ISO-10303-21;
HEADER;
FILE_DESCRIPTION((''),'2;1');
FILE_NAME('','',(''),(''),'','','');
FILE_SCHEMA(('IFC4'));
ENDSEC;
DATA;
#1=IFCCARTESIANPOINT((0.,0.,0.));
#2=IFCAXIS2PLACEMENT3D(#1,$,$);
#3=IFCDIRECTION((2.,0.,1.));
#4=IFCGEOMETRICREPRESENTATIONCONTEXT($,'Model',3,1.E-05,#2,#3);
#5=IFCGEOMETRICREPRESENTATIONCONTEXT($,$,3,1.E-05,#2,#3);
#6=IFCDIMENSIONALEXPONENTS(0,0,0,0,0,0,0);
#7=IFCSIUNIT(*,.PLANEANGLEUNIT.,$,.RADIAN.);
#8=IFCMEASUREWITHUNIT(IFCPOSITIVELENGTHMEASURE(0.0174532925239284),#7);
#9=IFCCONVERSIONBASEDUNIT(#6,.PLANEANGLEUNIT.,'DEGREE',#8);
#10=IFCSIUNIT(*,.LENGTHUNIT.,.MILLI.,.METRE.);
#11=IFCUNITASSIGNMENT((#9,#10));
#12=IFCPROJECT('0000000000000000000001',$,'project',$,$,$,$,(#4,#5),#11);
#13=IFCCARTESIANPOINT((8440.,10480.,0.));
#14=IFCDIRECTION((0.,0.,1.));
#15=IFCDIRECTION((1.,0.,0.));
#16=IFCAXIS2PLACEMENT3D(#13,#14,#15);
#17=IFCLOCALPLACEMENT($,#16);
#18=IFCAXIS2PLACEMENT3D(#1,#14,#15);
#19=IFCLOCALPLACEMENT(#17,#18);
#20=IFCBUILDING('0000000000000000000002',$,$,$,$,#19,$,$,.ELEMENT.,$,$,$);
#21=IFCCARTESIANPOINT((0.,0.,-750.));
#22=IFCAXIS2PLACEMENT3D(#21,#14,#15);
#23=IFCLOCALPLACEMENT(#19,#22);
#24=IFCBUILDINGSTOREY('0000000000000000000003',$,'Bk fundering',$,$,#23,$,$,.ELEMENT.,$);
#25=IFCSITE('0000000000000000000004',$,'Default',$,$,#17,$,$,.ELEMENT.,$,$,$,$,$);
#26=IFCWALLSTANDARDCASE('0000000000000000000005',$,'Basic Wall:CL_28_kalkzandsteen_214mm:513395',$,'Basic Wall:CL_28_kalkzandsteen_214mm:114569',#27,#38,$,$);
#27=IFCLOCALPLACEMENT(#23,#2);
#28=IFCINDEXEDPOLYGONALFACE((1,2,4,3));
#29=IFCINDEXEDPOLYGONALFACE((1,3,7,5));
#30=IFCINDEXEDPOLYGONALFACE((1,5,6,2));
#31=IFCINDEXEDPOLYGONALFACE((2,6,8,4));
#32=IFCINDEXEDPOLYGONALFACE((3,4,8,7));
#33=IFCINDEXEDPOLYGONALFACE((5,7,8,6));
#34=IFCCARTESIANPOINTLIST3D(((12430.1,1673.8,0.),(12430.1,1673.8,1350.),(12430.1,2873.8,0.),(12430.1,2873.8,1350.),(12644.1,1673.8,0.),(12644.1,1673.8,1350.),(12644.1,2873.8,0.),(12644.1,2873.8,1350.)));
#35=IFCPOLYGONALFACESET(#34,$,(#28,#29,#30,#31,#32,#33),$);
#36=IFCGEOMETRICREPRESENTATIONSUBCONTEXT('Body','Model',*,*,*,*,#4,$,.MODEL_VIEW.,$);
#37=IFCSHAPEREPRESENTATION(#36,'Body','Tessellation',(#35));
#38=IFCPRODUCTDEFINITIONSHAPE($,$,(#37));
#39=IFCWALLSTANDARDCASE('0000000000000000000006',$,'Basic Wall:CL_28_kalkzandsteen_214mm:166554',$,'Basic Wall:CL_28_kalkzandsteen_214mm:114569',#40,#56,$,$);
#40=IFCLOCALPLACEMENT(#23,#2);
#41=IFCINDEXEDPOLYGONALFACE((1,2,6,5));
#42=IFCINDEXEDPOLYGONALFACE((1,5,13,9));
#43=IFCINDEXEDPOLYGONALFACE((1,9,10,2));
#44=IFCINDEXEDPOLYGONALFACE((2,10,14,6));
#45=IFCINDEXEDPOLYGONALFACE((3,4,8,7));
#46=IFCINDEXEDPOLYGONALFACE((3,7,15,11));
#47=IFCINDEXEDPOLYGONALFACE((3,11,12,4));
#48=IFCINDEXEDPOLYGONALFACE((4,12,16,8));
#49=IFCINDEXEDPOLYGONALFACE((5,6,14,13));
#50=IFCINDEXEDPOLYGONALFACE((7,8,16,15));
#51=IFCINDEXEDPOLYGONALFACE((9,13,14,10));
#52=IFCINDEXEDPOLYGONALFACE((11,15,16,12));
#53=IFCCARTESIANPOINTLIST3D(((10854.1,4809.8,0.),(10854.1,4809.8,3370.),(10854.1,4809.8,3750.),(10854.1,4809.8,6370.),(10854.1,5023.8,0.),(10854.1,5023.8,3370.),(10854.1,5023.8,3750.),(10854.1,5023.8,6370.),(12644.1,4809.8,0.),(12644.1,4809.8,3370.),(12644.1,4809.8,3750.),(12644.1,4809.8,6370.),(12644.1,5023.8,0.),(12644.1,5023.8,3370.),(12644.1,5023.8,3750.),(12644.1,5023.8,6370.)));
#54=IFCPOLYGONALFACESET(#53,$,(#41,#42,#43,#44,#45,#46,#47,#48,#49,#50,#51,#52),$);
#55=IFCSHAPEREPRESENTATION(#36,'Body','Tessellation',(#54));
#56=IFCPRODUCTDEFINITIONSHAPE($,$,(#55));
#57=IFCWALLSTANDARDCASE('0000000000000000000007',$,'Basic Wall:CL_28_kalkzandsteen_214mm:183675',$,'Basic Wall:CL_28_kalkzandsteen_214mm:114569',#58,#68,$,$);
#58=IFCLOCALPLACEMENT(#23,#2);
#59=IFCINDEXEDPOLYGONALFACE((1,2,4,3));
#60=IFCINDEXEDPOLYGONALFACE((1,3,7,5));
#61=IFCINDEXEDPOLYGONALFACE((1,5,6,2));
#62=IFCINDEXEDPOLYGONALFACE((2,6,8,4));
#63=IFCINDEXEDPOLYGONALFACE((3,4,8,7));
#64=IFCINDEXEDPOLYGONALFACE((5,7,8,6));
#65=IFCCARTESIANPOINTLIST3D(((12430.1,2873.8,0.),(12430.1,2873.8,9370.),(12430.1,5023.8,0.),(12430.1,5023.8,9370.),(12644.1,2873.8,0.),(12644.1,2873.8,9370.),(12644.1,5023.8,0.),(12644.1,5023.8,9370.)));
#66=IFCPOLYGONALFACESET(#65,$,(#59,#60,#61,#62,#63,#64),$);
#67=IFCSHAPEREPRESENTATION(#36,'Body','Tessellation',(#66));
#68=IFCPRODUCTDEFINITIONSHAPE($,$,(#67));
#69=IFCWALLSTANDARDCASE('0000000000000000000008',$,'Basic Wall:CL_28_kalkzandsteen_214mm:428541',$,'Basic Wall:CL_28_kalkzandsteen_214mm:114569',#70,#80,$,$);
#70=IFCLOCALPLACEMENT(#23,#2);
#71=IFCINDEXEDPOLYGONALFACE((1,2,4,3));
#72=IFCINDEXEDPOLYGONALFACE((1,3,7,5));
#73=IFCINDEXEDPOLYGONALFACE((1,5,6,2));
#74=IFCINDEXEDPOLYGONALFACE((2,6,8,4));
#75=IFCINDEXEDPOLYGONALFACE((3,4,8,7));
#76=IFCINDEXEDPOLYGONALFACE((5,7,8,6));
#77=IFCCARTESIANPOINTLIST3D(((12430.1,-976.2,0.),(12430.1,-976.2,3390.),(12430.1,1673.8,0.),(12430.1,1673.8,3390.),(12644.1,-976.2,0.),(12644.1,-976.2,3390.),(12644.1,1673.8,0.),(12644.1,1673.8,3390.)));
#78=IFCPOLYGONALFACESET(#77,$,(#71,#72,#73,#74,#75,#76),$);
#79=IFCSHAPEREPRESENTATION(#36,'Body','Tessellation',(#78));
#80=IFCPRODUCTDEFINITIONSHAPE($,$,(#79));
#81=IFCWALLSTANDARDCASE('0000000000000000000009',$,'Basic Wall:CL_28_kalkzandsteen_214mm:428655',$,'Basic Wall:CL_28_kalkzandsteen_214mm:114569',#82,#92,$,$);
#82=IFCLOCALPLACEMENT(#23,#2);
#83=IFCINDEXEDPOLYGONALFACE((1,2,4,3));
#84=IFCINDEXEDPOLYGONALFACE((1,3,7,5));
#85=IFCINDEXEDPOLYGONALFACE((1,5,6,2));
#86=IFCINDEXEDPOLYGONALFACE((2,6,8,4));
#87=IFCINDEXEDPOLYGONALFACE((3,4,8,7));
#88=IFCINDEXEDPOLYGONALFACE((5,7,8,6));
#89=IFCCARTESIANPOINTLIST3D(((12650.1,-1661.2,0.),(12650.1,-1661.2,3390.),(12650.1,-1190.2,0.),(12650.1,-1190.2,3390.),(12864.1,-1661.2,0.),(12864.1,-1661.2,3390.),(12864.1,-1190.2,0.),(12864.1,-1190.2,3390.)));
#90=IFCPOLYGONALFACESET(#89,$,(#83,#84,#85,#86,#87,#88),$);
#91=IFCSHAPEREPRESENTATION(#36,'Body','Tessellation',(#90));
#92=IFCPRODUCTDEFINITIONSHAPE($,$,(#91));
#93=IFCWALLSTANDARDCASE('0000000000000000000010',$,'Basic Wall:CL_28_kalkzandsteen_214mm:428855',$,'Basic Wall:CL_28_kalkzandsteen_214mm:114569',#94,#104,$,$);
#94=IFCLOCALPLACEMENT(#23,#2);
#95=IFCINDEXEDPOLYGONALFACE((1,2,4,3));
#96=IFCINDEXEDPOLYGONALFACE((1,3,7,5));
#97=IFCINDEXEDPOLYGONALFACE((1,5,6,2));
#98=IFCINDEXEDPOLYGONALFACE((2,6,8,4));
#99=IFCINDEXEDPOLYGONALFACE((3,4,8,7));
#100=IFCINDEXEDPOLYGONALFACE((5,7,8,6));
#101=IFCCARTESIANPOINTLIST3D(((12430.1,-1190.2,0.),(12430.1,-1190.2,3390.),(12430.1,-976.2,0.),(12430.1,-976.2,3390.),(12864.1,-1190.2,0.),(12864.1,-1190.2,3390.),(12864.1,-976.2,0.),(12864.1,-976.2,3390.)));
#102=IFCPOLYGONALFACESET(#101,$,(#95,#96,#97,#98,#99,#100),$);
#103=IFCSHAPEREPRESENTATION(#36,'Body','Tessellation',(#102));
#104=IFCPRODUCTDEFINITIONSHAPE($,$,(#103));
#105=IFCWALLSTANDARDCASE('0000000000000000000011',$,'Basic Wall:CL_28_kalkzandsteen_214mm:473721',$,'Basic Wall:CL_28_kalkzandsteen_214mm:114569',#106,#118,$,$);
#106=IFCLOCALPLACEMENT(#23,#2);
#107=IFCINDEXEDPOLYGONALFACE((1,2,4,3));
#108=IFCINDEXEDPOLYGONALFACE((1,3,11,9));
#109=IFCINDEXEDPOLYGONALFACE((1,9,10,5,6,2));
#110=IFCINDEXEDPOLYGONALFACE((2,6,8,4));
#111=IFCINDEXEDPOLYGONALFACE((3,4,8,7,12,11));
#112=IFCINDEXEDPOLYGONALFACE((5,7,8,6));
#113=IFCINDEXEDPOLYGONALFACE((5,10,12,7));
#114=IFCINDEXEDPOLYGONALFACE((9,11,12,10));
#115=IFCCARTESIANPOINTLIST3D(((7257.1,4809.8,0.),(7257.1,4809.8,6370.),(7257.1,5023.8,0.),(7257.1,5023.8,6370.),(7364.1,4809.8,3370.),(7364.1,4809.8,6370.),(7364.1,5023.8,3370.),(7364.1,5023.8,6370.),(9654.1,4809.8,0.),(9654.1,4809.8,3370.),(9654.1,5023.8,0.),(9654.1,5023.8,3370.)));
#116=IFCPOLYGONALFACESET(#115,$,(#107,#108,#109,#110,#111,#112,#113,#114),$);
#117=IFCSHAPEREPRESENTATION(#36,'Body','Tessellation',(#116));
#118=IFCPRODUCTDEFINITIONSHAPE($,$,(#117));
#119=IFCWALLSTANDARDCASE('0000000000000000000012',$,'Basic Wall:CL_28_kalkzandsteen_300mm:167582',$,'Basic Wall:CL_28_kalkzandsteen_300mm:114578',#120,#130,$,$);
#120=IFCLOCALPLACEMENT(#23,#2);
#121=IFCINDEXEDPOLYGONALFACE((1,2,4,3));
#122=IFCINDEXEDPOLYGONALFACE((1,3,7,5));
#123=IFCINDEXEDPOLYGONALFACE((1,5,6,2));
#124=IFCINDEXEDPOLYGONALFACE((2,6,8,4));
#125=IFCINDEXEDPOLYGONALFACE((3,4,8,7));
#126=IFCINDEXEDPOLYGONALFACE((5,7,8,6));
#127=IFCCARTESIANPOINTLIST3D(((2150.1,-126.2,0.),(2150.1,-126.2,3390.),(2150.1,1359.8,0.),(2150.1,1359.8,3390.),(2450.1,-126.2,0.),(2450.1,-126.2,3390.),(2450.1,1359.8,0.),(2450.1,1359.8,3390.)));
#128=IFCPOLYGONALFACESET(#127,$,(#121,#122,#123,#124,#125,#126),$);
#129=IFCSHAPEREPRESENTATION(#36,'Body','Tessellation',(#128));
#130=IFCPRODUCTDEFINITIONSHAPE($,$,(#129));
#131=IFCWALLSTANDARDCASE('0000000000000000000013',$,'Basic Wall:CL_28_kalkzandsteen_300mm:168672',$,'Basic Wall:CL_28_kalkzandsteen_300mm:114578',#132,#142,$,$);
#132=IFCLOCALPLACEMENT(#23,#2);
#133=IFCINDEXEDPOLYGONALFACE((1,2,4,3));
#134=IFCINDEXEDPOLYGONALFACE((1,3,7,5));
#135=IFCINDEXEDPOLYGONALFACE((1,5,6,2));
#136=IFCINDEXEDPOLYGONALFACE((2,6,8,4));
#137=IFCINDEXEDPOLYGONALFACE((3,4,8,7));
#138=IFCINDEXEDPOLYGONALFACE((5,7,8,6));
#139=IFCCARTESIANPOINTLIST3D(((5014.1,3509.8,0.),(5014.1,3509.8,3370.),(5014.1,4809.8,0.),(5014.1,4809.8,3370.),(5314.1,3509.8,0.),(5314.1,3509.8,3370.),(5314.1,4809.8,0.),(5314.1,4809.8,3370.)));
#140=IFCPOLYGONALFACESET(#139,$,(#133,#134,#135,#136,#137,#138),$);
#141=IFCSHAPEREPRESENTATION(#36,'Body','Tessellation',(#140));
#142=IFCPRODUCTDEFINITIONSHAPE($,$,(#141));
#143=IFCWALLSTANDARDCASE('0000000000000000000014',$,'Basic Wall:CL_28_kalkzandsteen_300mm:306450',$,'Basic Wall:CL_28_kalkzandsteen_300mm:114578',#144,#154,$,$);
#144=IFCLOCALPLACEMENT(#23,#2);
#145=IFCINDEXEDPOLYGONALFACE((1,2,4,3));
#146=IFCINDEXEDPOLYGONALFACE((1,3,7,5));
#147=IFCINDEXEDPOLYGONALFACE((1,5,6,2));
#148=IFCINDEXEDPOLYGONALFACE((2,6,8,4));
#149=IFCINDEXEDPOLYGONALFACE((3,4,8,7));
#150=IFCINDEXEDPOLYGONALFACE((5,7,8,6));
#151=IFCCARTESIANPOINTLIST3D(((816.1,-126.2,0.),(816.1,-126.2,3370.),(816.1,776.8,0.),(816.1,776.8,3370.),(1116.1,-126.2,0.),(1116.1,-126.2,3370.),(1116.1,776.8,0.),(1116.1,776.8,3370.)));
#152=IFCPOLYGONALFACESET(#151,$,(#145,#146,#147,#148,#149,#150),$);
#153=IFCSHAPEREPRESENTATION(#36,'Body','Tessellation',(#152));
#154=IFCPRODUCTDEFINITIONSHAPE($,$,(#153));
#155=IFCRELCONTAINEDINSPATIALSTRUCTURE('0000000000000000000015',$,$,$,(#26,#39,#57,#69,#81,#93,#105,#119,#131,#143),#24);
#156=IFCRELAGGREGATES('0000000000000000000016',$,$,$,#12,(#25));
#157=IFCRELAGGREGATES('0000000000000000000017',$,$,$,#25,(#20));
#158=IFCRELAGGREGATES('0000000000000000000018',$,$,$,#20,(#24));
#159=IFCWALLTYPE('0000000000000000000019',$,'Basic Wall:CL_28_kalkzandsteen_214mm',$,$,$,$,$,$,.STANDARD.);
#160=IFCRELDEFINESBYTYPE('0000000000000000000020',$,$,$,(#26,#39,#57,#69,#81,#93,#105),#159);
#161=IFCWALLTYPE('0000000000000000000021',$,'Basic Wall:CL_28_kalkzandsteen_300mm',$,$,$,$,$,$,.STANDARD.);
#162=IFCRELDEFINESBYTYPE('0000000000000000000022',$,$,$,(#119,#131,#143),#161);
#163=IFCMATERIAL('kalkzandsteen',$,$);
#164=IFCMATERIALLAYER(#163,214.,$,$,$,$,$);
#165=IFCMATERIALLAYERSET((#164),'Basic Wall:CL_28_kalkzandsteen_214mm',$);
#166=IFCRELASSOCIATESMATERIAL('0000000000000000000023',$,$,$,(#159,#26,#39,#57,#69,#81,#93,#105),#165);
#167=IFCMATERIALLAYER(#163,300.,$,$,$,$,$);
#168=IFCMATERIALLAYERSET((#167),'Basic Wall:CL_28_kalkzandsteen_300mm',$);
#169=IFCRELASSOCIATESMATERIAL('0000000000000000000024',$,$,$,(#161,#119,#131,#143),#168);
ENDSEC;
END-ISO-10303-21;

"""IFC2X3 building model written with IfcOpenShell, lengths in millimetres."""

from ifc_helpers import new_model, entity, si_unit, converted_unit, direction, frame, frame_2d, origin, origin_with_axes, place, context, subcontext, project, spatial, polyline, rectangle, extrude, clip, bounded_halfspace, source, transform, mapped, material, layer, layer_set, layer_usage, type_object, element, save


model = new_model("IFC2X3")

# Units and contexts
model_context = context("Model", 3, precision=1e-05, world=origin(), true_north=direction((2.0, 0.0, 1.0)))
context_of_model = context(None, 3, precision=1e-05, world=origin(), true_north=direction((2.0, 0.0, 1.0)))
body_context = subcontext(model_context, "Body", "Model", "MODEL_VIEW")
ifc_project = project(units=[converted_unit("PLANEANGLEUNIT", "DEGREE", entity("IfcPositiveLengthMeasure", 0.0174532925239284), si_unit("PLANEANGLEUNIT", "RADIAN"), dimensions=[0, 0, 0, 0, 0, 0, 0]), si_unit("LENGTHUNIT", "METRE", prefix="MILLI")], contexts=[model_context, context_of_model])

# Site, building, storey
site_placement = place(None, frame((8440.0, 10480.0, 0.0), z_axis=(0.0, 0.0, 1.0), x_axis=(1.0, 0.0, 0.0)))
site = spatial("IfcSite", under=ifc_project, at=site_placement, Name="Default", CompositionType="ELEMENT")
building_placement = place(site_placement, origin_with_axes())
building = spatial("IfcBuilding", under=site, at=building_placement, CompositionType="ELEMENT")
storey_placement = place(building_placement, frame((0.0, 0.0, -750.0), z_axis=(0.0, 0.0, 1.0), x_axis=(1.0, 0.0, 0.0)))
storey = spatial("IfcBuildingStorey", under=building, at=storey_placement, Name="Bk fundering", CompositionType="ELEMENT")

# Wall
ifc_material_1 = material(Name="kalkzandsteen")
ifc_layer_1 = layer(ifc_material_1, 214.0)
ifc_layer_set_1 = layer_set([ifc_layer_1], Name="Basic Wall:CL_28_kalkzandsteen_214mm")
wall_type_1 = type_object("IfcWallType", Name="Basic Wall:CL_28_kalkzandsteen_214mm", PredefinedType="STANDARD", material=ifc_layer_set_1)
shared_shape_1 = source(origin(), body_context, "Body", "SweptSolid", [
    extrude(rectangle(XDim=1200.0, YDim=214.0, at=frame_2d((600.0, 0.0), x_axis=(-1.0, 0.0))), origin(), (0.0, 0.0, 1.0), 1350.0),
])
ifc_layer_usage_1 = layer_usage(ifc_layer_set_1, "AXIS2", "NEGATIVE", 107.0)
wall_1_placement = place(storey_placement, frame((12537.1, 1673.8, 0.0), z_axis=(0.0, 0.0, 1.0), x_axis=(0.0, 1.0, 0.0)))
element("IfcWallStandardCase", 1, at=wall_1_placement, inside=storey, type_object=wall_type_1, material=ifc_layer_usage_1, Name="Basic Wall:CL_28_kalkzandsteen_214mm:513395", ObjectType="Basic Wall:CL_28_kalkzandsteen_214mm:114569", context=body_context, shape_type="MappedRepresentation", body=[
    mapped(shared_shape_1, transform((0.0, 0.0, 0.0))),
])

# Wall, opening
ifc_layer_usage_2 = layer_usage(ifc_layer_set_1, "AXIS2", "NEGATIVE", 107.0)
wall_2_placement = place(storey_placement, frame((12644.1, 4916.8, 0.0), z_axis=(0.0, 0.0, 1.0), x_axis=(-1.0, 0.0, 0.0)))
wall_2 = element("IfcWallStandardCase", 2, at=wall_2_placement, inside=storey, type_object=wall_type_1, material=ifc_layer_usage_2, Name="Basic Wall:CL_28_kalkzandsteen_214mm:166554", ObjectType="Basic Wall:CL_28_kalkzandsteen_214mm:114569", context=body_context, shape_type="Clipping", body=[
    clip(extrude(rectangle(XDim=1790.0, YDim=214.0, at=frame_2d((895.0, 0.0), x_axis=(-1.0, 0.0))), origin(), (0.0, 0.0, 1.0), 6370.0), bounded_halfspace(frame((0.0, -107.0, 6370.0), z_axis=(0.0, 0.0, -1.0), x_axis=(-1.0, 0.0, 0.0)), True, frame((0.0, -107.0, 6370.0)), polyline([(0.0, 0.0), (1790.0, 0.0), (1790.0, 214.0), (0.0, 214.0), (0.0, 0.0)]))),
])
opening_placement = place(wall_2_placement, origin_with_axes())
element("IfcOpeningElement", 3, at=opening_placement, cuts=wall_2, ObjectType="Opening", context=body_context, shape_type="SweptSolid", body=[
    extrude(rectangle(XDim=1790.0, YDim=214.0, at=frame_2d((0.0, 0.0), x_axis=(1.0, 0.0))), frame((895.0, 0.0, 3370.0)), (0.0, 0.0, 1.0), 380.0),
])

# Walls
ifc_layer_usage_3 = layer_usage(ifc_layer_set_1, "AXIS2", "NEGATIVE", 107.0)
wall_3_placement = place(storey_placement, frame((12537.1, 2873.8, 0.0), z_axis=(0.0, 0.0, 1.0), x_axis=(0.0, 1.0, 0.0)))
element("IfcWallStandardCase", 4, at=wall_3_placement, inside=storey, type_object=wall_type_1, material=ifc_layer_usage_3, Name="Basic Wall:CL_28_kalkzandsteen_214mm:183675", ObjectType="Basic Wall:CL_28_kalkzandsteen_214mm:114569", context=body_context, shape_type="Clipping", body=[
    clip(extrude(rectangle(XDim=2150.0, YDim=214.0, at=frame_2d((1075.0, 0.0), x_axis=(-1.0, 0.0))), origin(), (0.0, 0.0, 1.0), 9370.0), bounded_halfspace(frame((0.0, -107.0, 9370.0), z_axis=(0.0, 0.0, -1.0), x_axis=(0.0, -1.0, 0.0)), True, frame((0.0, -107.0, 9370.0)), polyline([(0.0, 0.0), (2150.0, 0.0), (2150.0, 214.0), (1936.0, 214.0), (0.0, 214.0), (0.0, 0.0)]))),
])
ifc_layer_usage_4 = layer_usage(ifc_layer_set_1, "AXIS2", "NEGATIVE", 107.0)
wall_4_placement = place(storey_placement, frame((12537.1, -976.2, 0.0), z_axis=(0.0, 0.0, 1.0), x_axis=(0.0, 1.0, 0.0)))
element("IfcWallStandardCase", 5, at=wall_4_placement, inside=storey, type_object=wall_type_1, material=ifc_layer_usage_4, Name="Basic Wall:CL_28_kalkzandsteen_214mm:428541", ObjectType="Basic Wall:CL_28_kalkzandsteen_214mm:114569", context=body_context, shape_type="SweptSolid", body=[
    extrude(rectangle(XDim=2650.0, YDim=214.0, at=frame_2d((1325.0, 0.0), x_axis=(-1.0, 0.0))), origin(), (0.0, 0.0, 1.0), 3390.0),
])
ifc_layer_usage_5 = layer_usage(ifc_layer_set_1, "AXIS2", "NEGATIVE", 107.0)
wall_5_placement = place(storey_placement, frame((12757.1, -1661.2, 0.0), z_axis=(0.0, 0.0, 1.0), x_axis=(0.0, 1.0, 0.0)))
element("IfcWallStandardCase", 6, at=wall_5_placement, inside=storey, type_object=wall_type_1, material=ifc_layer_usage_5, Name="Basic Wall:CL_28_kalkzandsteen_214mm:428655", ObjectType="Basic Wall:CL_28_kalkzandsteen_214mm:114569", context=body_context, shape_type="SweptSolid", body=[
    extrude(rectangle(XDim=471.0, YDim=214.0, at=frame_2d((235.5, 0.0), x_axis=(-1.0, 0.0))), origin(), (0.0, 0.0, 1.0), 3390.0),
])
ifc_layer_usage_6 = layer_usage(ifc_layer_set_1, "AXIS2", "NEGATIVE", 107.0)
wall_6_placement = place(storey_placement, frame((12864.1, -1083.2, 0.0), z_axis=(0.0, 0.0, 1.0), x_axis=(-1.0, 0.0, 0.0)))
element("IfcWallStandardCase", 7, at=wall_6_placement, inside=storey, type_object=wall_type_1, material=ifc_layer_usage_6, Name="Basic Wall:CL_28_kalkzandsteen_214mm:428855", ObjectType="Basic Wall:CL_28_kalkzandsteen_214mm:114569", context=body_context, shape_type="SweptSolid", body=[
    extrude(rectangle(XDim=434.0, YDim=214.0, at=frame_2d((217.0, 0.0), x_axis=(-1.0, 0.0))), origin(), (0.0, 0.0, 1.0), 3390.0),
])
ifc_layer_usage_7 = layer_usage(ifc_layer_set_1, "AXIS2", "NEGATIVE", 107.0)
wall_7_placement = place(storey_placement, frame((9654.1, 4916.8, 0.0), z_axis=(0.0, 0.0, 1.0), x_axis=(-1.0, 0.0, 0.0)))
element("IfcWallStandardCase", 8, at=wall_7_placement, inside=storey, type_object=wall_type_1, material=ifc_layer_usage_7, Name="Basic Wall:CL_28_kalkzandsteen_214mm:473721", ObjectType="Basic Wall:CL_28_kalkzandsteen_214mm:114569", context=body_context, shape_type="Clipping", body=[
    clip(clip(extrude(rectangle(XDim=2397.0, YDim=214.0, at=frame_2d((1198.5, 0.0), x_axis=(-1.0, 0.0))), origin(), (0.0, 0.0, 1.0), 6370.0), bounded_halfspace(frame((0.0, -107.0, 6370.0), z_axis=(0.0, 0.0, -1.0), x_axis=(-1.0, 0.0, 0.0)), True, frame((0.0, -107.0, 6370.0)), polyline([(0.0, 0.0), (2397.0, 0.0), (2397.0, 214.0), (0.0, 214.0), (0.0, 0.0)]))), bounded_halfspace(frame((0.0, -107.0, 3370.0), z_axis=(0.0, 0.0, -1.0), x_axis=(-1.0, 0.0, 0.0)), True, frame((0.0, -107.0, 3370.0), z_axis=(0.0, 0.0, -1.0), x_axis=(-1.0, 0.0, 0.0)), polyline([(0.0, 0.0), (0.0, 214.0), (-2290.0, 214.0), (-2290.0, 0.0), (0.0, 0.0)]))),
])
ifc_layer_2 = layer(ifc_material_1, 300.0)
ifc_layer_set_2 = layer_set([ifc_layer_2], Name="Basic Wall:CL_28_kalkzandsteen_300mm")
ifc_layer_usage_8 = layer_usage(ifc_layer_set_2, "AXIS2", "NEGATIVE", 150.0)
wall_type_2 = type_object("IfcWallType", Name="Basic Wall:CL_28_kalkzandsteen_300mm", PredefinedType="STANDARD", material=ifc_layer_set_2)
wall_8_placement = place(storey_placement, frame((2300.1, -126.2, 0.0), z_axis=(0.0, 0.0, 1.0), x_axis=(0.0, 1.0, 0.0)))
element("IfcWallStandardCase", 9, at=wall_8_placement, inside=storey, type_object=wall_type_2, material=ifc_layer_usage_8, Name="Basic Wall:CL_28_kalkzandsteen_300mm:167582", ObjectType="Basic Wall:CL_28_kalkzandsteen_300mm:114578", context=body_context, shape_type="SweptSolid", body=[
    extrude(rectangle(XDim=1486.0, YDim=300.0, at=frame_2d((743.0, 0.0), x_axis=(-1.0, 0.0))), origin(), (0.0, 0.0, 1.0), 3390.0),
])
ifc_layer_usage_9 = layer_usage(ifc_layer_set_2, "AXIS2", "NEGATIVE", 150.0)
wall_9_placement = place(storey_placement, frame((5164.1, 4809.8, 0.0), z_axis=(0.0, 0.0, 1.0), x_axis=(0.0, -1.0, 0.0)))
element("IfcWallStandardCase", 10, at=wall_9_placement, inside=storey, type_object=wall_type_2, material=ifc_layer_usage_9, Name="Basic Wall:CL_28_kalkzandsteen_300mm:168672", ObjectType="Basic Wall:CL_28_kalkzandsteen_300mm:114578", context=body_context, shape_type="Clipping", body=[
    clip(extrude(rectangle(XDim=1300.0, YDim=300.0, at=frame_2d((650.0, 0.0), x_axis=(-1.0, 0.0))), origin(), (0.0, 0.0, 1.0), 3370.0), bounded_halfspace(frame((0.0, -150.0, 3370.0), z_axis=(0.0, 0.0, -1.0), x_axis=(0.0, 1.0, 0.0)), True, frame((0.0, -150.0, 3370.0)), polyline([(0.0, 0.0), (1300.0, 0.0), (1300.0, 300.0), (0.0, 300.0), (0.0, 0.0)]))),
])
ifc_layer_usage_10 = layer_usage(ifc_layer_set_2, "AXIS2", "NEGATIVE", 150.0)
wall_10_placement = place(storey_placement, frame((966.1, -126.2, 0.0), z_axis=(0.0, 0.0, 1.0), x_axis=(0.0, 1.0, 0.0)))
element("IfcWallStandardCase", 11, at=wall_10_placement, inside=storey, type_object=wall_type_2, material=ifc_layer_usage_10, Name="Basic Wall:CL_28_kalkzandsteen_300mm:306450", ObjectType="Basic Wall:CL_28_kalkzandsteen_300mm:114578", context=body_context, shape_type="Clipping", body=[
    clip(extrude(rectangle(XDim=903.0, YDim=300.0, at=frame_2d((451.5, 0.0), x_axis=(-1.0, 0.0))), origin(), (0.0, 0.0, 1.0), 3370.0), bounded_halfspace(frame((0.0, -150.0, 3370.0), z_axis=(0.0, 0.0, -1.0), x_axis=(0.0, -1.0, 0.0)), True, frame((0.0, -150.0, 3370.0)), polyline([(0.0, 0.0), (903.0, 0.0), (903.0, 300.0), (300.0, 300.0), (0.0, 300.0), (0.0, 0.0)]))),
])

save(model, "model.ifc")
